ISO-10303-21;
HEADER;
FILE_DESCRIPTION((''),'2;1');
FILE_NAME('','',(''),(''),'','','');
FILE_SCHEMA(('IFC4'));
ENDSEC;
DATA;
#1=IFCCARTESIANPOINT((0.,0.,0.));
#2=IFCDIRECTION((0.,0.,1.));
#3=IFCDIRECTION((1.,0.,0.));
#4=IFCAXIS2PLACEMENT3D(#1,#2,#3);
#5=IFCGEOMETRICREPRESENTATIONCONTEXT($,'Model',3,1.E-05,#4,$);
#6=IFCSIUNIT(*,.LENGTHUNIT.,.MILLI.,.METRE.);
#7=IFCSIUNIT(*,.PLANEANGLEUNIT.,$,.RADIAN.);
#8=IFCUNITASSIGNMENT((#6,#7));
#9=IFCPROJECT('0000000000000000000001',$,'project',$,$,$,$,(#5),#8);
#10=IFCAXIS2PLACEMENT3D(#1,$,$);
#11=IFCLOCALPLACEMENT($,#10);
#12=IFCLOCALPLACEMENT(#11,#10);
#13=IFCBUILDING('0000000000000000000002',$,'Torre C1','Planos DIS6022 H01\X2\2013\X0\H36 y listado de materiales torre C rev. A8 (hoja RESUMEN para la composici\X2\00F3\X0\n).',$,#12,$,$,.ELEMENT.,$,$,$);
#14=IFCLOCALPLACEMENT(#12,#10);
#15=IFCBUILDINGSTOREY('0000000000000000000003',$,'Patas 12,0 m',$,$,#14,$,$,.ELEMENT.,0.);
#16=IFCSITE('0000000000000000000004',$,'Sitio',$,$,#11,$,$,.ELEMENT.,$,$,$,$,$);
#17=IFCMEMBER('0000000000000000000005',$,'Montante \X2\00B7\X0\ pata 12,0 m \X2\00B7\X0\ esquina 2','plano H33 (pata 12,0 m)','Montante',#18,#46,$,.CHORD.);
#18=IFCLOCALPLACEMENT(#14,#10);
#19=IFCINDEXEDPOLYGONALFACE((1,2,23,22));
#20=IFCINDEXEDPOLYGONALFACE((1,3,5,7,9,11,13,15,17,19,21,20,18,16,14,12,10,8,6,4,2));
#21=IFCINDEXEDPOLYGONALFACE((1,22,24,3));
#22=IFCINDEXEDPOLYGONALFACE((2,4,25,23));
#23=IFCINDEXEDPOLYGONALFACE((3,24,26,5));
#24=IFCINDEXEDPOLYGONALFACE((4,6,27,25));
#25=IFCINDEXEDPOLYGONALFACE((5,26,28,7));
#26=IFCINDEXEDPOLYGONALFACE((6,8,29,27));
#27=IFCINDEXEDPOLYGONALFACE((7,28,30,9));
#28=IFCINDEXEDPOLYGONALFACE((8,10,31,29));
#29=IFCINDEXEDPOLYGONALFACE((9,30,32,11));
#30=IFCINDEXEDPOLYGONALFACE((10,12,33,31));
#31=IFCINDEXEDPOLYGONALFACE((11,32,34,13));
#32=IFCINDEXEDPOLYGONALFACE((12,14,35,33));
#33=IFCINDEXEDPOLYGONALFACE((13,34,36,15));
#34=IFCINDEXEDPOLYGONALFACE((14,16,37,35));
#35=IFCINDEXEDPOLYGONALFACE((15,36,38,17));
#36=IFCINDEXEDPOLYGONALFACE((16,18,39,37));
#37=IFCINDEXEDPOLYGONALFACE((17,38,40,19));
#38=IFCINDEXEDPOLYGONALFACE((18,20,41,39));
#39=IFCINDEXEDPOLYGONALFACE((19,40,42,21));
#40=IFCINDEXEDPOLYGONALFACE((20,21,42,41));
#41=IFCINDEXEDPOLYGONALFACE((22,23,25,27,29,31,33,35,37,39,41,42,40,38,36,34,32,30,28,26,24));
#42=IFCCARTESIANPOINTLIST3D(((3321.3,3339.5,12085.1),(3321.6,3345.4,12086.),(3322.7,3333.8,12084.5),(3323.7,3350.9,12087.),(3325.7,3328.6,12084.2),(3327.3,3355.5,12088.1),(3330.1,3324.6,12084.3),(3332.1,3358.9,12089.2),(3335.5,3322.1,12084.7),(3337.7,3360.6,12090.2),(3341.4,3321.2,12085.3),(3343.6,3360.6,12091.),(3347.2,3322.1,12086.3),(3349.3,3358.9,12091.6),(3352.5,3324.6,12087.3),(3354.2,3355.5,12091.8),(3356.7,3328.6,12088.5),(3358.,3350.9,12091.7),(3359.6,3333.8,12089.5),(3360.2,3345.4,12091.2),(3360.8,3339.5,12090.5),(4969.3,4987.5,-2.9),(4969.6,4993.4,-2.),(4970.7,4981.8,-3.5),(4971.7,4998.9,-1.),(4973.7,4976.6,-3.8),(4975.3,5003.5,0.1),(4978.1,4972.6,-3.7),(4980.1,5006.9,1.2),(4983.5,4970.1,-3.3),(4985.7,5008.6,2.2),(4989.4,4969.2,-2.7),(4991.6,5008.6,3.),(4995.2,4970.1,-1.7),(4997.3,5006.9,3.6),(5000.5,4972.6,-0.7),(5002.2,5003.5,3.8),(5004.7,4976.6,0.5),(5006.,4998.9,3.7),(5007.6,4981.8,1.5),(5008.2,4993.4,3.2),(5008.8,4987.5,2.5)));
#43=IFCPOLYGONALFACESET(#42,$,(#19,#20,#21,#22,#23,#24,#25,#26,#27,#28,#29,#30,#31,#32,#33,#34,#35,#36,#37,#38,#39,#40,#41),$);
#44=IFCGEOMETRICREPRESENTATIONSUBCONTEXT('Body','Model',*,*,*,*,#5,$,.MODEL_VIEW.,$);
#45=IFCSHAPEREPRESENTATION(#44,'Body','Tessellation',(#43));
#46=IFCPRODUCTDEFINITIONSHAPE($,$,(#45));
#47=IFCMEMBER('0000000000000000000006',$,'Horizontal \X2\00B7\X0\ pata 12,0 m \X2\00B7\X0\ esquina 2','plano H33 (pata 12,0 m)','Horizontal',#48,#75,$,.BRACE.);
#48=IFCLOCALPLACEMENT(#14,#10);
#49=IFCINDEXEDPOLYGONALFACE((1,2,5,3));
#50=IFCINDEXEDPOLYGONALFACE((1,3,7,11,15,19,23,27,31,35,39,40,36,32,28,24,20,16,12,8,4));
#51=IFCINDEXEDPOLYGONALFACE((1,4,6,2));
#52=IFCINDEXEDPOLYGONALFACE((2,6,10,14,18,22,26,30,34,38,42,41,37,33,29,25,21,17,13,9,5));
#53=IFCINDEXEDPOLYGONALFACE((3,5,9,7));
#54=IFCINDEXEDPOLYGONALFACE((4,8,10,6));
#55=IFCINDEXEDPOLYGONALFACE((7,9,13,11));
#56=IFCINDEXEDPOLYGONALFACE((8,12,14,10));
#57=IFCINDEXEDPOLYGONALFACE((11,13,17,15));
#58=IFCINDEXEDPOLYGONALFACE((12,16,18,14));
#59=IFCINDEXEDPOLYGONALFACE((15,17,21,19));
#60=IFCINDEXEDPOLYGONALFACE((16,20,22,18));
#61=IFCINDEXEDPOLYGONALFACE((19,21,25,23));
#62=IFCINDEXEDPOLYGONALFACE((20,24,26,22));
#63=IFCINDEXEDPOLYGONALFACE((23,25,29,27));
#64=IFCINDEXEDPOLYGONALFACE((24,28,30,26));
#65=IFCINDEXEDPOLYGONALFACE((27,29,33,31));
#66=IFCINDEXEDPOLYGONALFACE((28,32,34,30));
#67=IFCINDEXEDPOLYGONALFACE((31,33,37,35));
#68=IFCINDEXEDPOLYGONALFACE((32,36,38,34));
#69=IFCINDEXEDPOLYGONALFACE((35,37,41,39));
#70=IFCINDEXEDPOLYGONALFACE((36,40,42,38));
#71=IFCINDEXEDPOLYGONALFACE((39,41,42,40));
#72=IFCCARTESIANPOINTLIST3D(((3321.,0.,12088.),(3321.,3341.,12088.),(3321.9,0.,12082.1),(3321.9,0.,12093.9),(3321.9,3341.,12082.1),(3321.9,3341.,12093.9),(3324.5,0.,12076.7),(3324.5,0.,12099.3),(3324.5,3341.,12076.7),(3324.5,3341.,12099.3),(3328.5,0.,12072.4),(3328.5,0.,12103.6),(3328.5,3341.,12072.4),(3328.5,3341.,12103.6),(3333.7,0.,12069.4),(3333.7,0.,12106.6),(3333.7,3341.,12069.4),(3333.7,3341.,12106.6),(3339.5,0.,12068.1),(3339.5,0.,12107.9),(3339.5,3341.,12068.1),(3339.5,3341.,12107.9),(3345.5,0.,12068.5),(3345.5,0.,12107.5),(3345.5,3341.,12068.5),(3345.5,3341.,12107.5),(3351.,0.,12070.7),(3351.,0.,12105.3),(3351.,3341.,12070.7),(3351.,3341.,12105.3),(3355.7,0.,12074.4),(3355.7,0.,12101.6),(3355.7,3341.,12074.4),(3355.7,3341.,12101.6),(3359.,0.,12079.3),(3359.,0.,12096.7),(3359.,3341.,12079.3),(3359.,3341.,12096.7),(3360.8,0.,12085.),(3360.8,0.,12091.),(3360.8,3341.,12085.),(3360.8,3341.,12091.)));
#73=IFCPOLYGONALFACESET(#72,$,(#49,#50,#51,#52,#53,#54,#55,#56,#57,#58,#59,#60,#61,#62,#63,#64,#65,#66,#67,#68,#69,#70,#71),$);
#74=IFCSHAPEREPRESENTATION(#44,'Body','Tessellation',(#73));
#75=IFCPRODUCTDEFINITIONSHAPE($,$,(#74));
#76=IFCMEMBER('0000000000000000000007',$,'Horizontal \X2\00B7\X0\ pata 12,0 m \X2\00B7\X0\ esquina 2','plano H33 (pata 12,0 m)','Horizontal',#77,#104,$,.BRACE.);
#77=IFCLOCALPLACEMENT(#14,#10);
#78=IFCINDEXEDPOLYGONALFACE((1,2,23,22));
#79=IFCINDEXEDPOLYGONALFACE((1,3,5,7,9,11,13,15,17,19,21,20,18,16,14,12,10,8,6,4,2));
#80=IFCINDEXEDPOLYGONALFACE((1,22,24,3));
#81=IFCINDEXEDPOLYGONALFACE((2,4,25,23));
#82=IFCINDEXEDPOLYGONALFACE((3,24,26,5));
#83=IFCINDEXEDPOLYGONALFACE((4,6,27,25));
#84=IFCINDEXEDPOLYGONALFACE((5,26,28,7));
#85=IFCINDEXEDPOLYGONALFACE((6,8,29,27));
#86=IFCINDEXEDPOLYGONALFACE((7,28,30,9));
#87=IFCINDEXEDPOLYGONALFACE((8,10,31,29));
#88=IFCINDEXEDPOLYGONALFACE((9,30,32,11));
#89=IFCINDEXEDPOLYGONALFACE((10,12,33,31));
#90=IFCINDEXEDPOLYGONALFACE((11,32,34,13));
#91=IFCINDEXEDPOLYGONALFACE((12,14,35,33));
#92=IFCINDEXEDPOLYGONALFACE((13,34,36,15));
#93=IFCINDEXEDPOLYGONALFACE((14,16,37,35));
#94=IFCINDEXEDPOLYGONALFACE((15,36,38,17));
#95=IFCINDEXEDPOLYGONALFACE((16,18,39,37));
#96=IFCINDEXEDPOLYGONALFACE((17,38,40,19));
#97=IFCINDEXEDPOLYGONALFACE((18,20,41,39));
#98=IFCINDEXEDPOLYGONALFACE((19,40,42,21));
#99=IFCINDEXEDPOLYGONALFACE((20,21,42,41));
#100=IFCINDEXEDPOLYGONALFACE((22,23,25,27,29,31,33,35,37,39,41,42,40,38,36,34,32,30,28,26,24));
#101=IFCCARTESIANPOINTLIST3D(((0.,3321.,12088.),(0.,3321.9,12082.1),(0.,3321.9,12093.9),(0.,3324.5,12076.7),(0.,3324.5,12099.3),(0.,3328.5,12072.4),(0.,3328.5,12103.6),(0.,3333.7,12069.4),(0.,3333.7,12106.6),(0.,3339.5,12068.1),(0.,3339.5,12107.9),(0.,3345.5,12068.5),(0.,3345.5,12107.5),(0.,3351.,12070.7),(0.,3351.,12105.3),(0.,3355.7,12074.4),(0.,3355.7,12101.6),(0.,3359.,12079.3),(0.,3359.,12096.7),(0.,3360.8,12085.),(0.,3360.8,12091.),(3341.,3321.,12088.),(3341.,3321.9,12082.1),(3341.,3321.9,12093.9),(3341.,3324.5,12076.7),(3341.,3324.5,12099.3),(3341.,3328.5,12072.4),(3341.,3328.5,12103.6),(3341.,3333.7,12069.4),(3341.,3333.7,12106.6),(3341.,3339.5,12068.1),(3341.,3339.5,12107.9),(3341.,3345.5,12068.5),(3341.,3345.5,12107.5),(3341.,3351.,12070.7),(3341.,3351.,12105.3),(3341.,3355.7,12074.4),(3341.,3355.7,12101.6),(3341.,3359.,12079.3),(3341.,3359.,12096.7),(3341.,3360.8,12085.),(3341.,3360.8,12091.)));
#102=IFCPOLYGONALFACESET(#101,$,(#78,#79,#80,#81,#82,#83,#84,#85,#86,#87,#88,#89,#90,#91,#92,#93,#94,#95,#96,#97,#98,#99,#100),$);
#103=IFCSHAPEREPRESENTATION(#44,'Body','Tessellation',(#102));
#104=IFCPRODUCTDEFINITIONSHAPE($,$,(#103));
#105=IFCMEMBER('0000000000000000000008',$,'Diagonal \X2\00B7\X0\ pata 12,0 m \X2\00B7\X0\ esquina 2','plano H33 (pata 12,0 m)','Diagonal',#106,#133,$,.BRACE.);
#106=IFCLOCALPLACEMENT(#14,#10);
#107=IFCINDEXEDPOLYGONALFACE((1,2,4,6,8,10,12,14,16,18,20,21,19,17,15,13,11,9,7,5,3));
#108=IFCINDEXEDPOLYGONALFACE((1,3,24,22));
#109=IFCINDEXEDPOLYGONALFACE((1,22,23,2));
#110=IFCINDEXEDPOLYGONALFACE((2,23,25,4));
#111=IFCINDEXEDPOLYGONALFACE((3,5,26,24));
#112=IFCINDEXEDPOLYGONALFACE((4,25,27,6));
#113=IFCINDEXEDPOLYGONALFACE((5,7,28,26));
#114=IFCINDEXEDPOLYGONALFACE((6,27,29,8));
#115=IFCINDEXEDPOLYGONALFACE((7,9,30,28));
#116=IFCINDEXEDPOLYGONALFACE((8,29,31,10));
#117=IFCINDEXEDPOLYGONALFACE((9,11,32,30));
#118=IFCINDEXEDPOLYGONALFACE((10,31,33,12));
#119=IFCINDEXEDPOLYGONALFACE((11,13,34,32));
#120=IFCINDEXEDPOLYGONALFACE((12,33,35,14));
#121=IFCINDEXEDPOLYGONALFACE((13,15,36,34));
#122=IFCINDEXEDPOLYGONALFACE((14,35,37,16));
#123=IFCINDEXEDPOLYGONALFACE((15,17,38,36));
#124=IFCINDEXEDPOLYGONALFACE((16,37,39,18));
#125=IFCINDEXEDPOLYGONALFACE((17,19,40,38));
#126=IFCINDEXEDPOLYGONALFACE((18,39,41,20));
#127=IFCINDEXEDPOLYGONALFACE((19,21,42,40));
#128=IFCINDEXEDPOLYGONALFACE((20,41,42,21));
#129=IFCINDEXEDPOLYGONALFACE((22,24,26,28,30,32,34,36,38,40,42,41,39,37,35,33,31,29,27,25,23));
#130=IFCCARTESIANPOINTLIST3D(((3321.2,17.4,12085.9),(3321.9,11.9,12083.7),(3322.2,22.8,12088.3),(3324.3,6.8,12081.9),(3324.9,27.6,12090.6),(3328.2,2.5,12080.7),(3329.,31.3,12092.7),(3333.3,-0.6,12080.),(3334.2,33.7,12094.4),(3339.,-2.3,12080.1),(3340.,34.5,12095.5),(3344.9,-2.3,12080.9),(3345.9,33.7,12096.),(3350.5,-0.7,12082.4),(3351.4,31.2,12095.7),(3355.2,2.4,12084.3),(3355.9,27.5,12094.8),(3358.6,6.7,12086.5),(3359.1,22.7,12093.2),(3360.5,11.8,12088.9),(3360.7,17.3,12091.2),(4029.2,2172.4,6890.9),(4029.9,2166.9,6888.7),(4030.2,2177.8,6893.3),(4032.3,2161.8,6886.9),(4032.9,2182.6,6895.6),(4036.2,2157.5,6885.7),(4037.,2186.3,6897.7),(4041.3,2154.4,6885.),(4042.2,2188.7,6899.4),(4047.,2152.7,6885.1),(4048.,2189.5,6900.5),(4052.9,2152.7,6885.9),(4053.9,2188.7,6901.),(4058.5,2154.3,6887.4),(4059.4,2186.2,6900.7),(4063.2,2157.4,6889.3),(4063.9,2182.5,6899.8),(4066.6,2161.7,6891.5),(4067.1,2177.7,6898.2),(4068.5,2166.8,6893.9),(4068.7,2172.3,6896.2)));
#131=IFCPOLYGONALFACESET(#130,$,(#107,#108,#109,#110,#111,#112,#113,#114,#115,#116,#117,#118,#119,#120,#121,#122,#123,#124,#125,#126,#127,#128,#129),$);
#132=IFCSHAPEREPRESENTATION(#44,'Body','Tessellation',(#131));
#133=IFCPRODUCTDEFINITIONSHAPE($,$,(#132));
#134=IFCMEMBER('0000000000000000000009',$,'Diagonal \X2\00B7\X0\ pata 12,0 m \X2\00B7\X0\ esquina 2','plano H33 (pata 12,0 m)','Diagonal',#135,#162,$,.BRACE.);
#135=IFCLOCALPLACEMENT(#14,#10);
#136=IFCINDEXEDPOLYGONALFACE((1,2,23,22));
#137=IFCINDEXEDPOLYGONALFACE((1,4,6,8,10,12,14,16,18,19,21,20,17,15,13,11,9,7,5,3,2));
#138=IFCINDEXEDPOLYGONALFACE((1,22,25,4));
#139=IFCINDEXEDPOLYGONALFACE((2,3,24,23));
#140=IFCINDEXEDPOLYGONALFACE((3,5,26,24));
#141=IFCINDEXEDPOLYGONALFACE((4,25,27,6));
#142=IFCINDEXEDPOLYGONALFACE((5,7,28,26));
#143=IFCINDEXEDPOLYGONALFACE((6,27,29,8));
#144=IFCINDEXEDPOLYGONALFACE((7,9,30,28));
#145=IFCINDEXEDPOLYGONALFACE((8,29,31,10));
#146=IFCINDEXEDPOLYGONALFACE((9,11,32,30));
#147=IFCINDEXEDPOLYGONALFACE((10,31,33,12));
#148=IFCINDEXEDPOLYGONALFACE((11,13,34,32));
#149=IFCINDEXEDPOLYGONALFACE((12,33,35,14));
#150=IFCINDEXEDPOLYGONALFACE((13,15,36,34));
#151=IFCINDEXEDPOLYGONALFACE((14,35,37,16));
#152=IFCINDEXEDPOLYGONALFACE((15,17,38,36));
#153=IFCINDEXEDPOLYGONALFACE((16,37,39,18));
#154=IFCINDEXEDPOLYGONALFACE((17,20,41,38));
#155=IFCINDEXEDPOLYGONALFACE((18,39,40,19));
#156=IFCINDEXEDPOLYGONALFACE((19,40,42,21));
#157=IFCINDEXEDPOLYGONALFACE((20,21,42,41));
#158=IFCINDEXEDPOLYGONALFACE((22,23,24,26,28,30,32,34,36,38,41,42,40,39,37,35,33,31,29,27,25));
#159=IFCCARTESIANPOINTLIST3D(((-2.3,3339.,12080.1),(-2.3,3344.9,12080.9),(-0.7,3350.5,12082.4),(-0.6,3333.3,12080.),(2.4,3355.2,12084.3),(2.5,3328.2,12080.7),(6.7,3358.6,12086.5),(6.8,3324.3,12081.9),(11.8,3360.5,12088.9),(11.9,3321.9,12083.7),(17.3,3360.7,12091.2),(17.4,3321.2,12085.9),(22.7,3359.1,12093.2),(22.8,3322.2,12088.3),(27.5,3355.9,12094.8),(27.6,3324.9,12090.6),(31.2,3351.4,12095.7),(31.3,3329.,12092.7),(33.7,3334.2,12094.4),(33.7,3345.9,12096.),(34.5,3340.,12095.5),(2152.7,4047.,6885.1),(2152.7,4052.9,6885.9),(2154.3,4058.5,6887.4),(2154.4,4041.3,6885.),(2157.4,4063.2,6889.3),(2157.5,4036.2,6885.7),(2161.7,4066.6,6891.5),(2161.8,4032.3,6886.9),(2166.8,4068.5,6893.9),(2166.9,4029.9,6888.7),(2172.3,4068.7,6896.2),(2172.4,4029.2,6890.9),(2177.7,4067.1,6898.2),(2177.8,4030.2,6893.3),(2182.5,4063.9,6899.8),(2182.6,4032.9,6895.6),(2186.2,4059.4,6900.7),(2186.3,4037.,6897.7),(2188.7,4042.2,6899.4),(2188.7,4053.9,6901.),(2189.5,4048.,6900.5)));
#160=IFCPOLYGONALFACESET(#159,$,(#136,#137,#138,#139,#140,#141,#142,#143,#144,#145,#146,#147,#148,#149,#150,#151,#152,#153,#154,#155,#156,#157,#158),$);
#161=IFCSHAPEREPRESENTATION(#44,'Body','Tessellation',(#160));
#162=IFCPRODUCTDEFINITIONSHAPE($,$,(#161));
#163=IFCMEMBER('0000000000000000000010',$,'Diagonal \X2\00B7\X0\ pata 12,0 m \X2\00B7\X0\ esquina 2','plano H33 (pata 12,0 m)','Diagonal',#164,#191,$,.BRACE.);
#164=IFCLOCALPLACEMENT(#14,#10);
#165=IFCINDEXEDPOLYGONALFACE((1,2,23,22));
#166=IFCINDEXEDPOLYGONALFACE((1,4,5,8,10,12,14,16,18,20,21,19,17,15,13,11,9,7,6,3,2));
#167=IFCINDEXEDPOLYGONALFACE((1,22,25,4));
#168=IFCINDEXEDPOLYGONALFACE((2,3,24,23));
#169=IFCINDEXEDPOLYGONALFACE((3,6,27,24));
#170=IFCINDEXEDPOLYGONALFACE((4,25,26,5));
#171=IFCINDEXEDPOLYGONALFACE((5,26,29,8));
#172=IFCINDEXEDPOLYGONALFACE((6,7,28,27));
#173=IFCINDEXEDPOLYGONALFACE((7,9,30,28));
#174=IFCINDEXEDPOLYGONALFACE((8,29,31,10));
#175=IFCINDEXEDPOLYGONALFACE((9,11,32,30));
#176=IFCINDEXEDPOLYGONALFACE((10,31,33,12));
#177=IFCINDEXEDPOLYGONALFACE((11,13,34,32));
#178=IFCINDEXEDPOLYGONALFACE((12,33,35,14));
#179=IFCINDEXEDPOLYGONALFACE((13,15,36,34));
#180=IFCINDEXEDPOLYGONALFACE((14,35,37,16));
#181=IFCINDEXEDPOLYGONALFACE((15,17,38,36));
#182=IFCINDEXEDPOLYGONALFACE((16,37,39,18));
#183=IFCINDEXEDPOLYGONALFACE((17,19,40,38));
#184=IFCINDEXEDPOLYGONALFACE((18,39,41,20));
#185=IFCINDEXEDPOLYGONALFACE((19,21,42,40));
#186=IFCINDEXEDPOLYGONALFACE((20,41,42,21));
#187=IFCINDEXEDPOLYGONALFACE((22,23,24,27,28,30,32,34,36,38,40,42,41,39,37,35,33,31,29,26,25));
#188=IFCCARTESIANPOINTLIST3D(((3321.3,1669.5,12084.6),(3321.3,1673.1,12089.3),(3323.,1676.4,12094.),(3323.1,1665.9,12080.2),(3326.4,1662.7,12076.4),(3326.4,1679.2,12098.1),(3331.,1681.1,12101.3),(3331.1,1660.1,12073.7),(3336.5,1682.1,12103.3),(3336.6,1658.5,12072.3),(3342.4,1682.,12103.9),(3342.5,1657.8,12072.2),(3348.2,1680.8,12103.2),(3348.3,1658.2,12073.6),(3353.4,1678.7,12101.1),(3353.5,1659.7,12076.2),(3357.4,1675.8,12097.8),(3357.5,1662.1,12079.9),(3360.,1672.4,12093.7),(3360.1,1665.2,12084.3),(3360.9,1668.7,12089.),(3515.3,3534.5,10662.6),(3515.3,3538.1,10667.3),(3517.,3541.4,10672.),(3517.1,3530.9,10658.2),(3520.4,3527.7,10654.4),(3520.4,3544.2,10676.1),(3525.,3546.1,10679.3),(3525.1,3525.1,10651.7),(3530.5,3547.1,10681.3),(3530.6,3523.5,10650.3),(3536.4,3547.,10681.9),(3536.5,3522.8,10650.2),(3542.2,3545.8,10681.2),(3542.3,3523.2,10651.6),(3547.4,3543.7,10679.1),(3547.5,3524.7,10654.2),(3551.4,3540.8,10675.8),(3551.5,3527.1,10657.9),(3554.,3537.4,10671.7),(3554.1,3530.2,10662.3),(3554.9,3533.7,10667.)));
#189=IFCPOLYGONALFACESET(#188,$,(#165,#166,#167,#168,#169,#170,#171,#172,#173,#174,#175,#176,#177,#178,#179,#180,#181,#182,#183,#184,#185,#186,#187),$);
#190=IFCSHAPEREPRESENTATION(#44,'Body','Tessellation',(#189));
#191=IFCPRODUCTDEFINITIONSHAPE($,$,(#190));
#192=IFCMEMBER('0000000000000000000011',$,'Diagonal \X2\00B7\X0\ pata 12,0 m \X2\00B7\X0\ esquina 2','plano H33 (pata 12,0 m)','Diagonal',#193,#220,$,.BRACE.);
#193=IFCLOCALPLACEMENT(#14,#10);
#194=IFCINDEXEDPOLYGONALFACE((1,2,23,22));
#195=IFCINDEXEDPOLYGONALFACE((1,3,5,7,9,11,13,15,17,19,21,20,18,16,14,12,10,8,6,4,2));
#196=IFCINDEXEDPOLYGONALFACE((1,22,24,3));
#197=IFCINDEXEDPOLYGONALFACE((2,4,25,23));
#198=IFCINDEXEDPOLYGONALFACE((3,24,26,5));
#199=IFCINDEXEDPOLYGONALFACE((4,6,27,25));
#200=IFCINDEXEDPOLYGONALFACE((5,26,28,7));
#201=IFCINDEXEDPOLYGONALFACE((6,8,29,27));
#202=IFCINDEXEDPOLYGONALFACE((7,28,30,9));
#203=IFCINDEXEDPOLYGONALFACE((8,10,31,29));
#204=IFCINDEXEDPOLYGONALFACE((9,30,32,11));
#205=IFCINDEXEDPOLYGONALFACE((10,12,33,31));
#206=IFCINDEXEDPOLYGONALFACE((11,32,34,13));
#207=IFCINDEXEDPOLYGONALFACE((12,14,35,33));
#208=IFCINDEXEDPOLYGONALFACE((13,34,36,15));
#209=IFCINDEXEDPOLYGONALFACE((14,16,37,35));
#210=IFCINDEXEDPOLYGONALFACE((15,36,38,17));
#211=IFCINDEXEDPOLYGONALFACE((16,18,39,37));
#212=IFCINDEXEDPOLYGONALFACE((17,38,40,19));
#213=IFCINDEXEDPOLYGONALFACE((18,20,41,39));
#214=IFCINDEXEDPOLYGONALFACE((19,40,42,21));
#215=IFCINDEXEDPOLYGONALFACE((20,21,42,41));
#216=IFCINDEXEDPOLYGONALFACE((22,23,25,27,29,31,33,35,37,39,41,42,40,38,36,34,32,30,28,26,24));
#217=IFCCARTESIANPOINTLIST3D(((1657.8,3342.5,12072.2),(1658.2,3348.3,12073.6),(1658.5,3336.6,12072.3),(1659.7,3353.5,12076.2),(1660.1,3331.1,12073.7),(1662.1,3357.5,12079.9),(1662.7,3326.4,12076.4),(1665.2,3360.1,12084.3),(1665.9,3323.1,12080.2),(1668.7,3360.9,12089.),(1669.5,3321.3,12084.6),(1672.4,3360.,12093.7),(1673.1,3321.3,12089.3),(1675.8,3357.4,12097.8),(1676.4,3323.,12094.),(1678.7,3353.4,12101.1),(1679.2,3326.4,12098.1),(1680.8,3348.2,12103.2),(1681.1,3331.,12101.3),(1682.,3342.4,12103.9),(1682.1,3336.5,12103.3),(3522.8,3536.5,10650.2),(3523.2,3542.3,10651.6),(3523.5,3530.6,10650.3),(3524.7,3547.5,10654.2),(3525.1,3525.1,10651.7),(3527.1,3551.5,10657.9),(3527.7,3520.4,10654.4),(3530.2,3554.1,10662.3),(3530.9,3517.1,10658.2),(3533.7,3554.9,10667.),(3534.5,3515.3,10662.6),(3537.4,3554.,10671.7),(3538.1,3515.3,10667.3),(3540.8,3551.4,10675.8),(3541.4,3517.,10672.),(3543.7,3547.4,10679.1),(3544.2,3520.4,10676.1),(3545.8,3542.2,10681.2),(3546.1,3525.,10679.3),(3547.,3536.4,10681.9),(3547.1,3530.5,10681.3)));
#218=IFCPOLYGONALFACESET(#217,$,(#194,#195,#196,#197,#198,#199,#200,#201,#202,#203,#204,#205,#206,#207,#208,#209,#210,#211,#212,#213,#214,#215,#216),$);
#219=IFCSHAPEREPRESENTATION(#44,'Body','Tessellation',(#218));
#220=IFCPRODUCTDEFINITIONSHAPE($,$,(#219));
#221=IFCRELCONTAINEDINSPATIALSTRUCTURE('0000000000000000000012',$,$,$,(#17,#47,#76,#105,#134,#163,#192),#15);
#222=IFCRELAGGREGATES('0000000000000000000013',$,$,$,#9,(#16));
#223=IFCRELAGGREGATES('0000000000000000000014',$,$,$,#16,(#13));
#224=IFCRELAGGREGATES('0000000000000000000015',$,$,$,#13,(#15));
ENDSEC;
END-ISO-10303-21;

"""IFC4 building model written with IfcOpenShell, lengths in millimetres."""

from ifc_helpers import new_model, si_unit, frame, origin, origin_with_axes, place, context, subcontext, project, spatial, circle, extrude, element, save


model = new_model("IFC4")

# Units and contexts
model_context = context("Model", 3, precision=1e-05, world=origin_with_axes())
body_context = subcontext(model_context, "Body", "Model", "MODEL_VIEW")
ifc_project = project(units=[si_unit("LENGTHUNIT", "METRE", prefix="MILLI"), si_unit("PLANEANGLEUNIT", "RADIAN")], contexts=[model_context])

# Site, building, storey
site_placement = place(None, origin())
site = spatial("IfcSite", under=ifc_project, at=site_placement, Name="Sitio", CompositionType="ELEMENT")
building_placement = place(site_placement, origin())
building = spatial("IfcBuilding", under=site, at=building_placement, Name="Torre C1", Description="Planos DIS6022 H01–H36 y listado de materiales torre C rev. A8 (hoja RESUMEN para la composición).", CompositionType="ELEMENT")
storey_placement = place(building_placement, origin())
storey = spatial("IfcBuildingStorey", under=building, at=storey_placement, Name="Patas 12,0 m", CompositionType="ELEMENT", Elevation=0.0)

# Members
member_1_placement = place(storey_placement, frame((3341.0, 3341.0, 12088.0), z_axis=(0.133868, 0.133868, -0.981916), x_axis=(0.018083, -0.990999, -0.132641)))
element("IfcMember", 1, at=member_1_placement, inside=storey, Name="Montante · pata 12,0 m · esquina 2", Description="plano H33 (pata 12,0 m)", ObjectType="Montante", PredefinedType="CHORD", context=body_context, shape_type="SweptSolid", body=[
    extrude(circle(Radius=20.0), None, (0.0, 0.0, 1.0), 12310.6),
])
for number, where, z_axis, x_axis, name in (
    (2, (3341.0, 3341.0, 12088.0), (0.0, -1.0, 0.0), (-1.0, 0.0, 0.0), "Horizontal · pata 12,0 m · esquina 2"),
    (3, (3341.0, 3341.0, 12088.0), (-1.0, 0.0, 0.0), (0.0, -1.0, 0.0), "Horizontal · pata 12,0 m · esquina 2"),
):
    element("IfcMember", number, at=place(storey_placement, frame(where, z_axis=z_axis, x_axis=x_axis)), inside=storey, Name=name, Description="plano H33 (pata 12,0 m)", ObjectType="Horizontal", PredefinedType="BRACE", context=body_context, shape_type="SweptSolid", body=[
        extrude(circle(Radius=20.0), None, (0.0, 0.0, 1.0), 3341.0),
    ])
for number, where, z_axis, x_axis, name in (
    (4, (3341.0, 16.0, 12088.0), (0.124898, 0.380163, -0.916448), (-0.955547, -0.202551, -0.214249), "Diagonal · pata 12,0 m · esquina 2"),
    (5, (16.0, 3341.0, 12088.0), (0.380163, 0.124898, -0.916448), (-0.202551, -0.955547, -0.214249), "Diagonal · pata 12,0 m · esquina 2"),
):
    element("IfcMember", number, at=place(storey_placement, frame(where, z_axis=z_axis, x_axis=x_axis)), inside=storey, Name=name, Description="plano H33 (pata 12,0 m)", ObjectType="Diagonal", PredefinedType="BRACE", context=body_context, shape_type="SweptSolid", body=[
        extrude(circle(Radius=20.0), None, (0.0, 0.0, 1.0), 5668.6),
    ])
for number, where, z_axis, x_axis, name in (
    (6, (3341.0, 1670.0, 12088.0), (0.082438, 0.79251, -0.604262), (-0.896811, -0.205457, -0.391813), "Diagonal · pata 12,0 m · esquina 2"),
    (7, (1670.0, 3341.0, 12088.0), (0.79251, 0.082438, -0.604262), (-0.205457, -0.896811, -0.391813), "Diagonal · pata 12,0 m · esquina 2"),
):
    element("IfcMember", number, at=place(storey_placement, frame(where, z_axis=z_axis, x_axis=x_axis)), inside=storey, Name=name, Description="plano H33 (pata 12,0 m)", ObjectType="Diagonal", PredefinedType="BRACE", context=body_context, shape_type="SweptSolid", body=[
        extrude(circle(Radius=20.0), None, (0.0, 0.0, 1.0), 2353.3),
    ])

save(model, "model.ifc")
